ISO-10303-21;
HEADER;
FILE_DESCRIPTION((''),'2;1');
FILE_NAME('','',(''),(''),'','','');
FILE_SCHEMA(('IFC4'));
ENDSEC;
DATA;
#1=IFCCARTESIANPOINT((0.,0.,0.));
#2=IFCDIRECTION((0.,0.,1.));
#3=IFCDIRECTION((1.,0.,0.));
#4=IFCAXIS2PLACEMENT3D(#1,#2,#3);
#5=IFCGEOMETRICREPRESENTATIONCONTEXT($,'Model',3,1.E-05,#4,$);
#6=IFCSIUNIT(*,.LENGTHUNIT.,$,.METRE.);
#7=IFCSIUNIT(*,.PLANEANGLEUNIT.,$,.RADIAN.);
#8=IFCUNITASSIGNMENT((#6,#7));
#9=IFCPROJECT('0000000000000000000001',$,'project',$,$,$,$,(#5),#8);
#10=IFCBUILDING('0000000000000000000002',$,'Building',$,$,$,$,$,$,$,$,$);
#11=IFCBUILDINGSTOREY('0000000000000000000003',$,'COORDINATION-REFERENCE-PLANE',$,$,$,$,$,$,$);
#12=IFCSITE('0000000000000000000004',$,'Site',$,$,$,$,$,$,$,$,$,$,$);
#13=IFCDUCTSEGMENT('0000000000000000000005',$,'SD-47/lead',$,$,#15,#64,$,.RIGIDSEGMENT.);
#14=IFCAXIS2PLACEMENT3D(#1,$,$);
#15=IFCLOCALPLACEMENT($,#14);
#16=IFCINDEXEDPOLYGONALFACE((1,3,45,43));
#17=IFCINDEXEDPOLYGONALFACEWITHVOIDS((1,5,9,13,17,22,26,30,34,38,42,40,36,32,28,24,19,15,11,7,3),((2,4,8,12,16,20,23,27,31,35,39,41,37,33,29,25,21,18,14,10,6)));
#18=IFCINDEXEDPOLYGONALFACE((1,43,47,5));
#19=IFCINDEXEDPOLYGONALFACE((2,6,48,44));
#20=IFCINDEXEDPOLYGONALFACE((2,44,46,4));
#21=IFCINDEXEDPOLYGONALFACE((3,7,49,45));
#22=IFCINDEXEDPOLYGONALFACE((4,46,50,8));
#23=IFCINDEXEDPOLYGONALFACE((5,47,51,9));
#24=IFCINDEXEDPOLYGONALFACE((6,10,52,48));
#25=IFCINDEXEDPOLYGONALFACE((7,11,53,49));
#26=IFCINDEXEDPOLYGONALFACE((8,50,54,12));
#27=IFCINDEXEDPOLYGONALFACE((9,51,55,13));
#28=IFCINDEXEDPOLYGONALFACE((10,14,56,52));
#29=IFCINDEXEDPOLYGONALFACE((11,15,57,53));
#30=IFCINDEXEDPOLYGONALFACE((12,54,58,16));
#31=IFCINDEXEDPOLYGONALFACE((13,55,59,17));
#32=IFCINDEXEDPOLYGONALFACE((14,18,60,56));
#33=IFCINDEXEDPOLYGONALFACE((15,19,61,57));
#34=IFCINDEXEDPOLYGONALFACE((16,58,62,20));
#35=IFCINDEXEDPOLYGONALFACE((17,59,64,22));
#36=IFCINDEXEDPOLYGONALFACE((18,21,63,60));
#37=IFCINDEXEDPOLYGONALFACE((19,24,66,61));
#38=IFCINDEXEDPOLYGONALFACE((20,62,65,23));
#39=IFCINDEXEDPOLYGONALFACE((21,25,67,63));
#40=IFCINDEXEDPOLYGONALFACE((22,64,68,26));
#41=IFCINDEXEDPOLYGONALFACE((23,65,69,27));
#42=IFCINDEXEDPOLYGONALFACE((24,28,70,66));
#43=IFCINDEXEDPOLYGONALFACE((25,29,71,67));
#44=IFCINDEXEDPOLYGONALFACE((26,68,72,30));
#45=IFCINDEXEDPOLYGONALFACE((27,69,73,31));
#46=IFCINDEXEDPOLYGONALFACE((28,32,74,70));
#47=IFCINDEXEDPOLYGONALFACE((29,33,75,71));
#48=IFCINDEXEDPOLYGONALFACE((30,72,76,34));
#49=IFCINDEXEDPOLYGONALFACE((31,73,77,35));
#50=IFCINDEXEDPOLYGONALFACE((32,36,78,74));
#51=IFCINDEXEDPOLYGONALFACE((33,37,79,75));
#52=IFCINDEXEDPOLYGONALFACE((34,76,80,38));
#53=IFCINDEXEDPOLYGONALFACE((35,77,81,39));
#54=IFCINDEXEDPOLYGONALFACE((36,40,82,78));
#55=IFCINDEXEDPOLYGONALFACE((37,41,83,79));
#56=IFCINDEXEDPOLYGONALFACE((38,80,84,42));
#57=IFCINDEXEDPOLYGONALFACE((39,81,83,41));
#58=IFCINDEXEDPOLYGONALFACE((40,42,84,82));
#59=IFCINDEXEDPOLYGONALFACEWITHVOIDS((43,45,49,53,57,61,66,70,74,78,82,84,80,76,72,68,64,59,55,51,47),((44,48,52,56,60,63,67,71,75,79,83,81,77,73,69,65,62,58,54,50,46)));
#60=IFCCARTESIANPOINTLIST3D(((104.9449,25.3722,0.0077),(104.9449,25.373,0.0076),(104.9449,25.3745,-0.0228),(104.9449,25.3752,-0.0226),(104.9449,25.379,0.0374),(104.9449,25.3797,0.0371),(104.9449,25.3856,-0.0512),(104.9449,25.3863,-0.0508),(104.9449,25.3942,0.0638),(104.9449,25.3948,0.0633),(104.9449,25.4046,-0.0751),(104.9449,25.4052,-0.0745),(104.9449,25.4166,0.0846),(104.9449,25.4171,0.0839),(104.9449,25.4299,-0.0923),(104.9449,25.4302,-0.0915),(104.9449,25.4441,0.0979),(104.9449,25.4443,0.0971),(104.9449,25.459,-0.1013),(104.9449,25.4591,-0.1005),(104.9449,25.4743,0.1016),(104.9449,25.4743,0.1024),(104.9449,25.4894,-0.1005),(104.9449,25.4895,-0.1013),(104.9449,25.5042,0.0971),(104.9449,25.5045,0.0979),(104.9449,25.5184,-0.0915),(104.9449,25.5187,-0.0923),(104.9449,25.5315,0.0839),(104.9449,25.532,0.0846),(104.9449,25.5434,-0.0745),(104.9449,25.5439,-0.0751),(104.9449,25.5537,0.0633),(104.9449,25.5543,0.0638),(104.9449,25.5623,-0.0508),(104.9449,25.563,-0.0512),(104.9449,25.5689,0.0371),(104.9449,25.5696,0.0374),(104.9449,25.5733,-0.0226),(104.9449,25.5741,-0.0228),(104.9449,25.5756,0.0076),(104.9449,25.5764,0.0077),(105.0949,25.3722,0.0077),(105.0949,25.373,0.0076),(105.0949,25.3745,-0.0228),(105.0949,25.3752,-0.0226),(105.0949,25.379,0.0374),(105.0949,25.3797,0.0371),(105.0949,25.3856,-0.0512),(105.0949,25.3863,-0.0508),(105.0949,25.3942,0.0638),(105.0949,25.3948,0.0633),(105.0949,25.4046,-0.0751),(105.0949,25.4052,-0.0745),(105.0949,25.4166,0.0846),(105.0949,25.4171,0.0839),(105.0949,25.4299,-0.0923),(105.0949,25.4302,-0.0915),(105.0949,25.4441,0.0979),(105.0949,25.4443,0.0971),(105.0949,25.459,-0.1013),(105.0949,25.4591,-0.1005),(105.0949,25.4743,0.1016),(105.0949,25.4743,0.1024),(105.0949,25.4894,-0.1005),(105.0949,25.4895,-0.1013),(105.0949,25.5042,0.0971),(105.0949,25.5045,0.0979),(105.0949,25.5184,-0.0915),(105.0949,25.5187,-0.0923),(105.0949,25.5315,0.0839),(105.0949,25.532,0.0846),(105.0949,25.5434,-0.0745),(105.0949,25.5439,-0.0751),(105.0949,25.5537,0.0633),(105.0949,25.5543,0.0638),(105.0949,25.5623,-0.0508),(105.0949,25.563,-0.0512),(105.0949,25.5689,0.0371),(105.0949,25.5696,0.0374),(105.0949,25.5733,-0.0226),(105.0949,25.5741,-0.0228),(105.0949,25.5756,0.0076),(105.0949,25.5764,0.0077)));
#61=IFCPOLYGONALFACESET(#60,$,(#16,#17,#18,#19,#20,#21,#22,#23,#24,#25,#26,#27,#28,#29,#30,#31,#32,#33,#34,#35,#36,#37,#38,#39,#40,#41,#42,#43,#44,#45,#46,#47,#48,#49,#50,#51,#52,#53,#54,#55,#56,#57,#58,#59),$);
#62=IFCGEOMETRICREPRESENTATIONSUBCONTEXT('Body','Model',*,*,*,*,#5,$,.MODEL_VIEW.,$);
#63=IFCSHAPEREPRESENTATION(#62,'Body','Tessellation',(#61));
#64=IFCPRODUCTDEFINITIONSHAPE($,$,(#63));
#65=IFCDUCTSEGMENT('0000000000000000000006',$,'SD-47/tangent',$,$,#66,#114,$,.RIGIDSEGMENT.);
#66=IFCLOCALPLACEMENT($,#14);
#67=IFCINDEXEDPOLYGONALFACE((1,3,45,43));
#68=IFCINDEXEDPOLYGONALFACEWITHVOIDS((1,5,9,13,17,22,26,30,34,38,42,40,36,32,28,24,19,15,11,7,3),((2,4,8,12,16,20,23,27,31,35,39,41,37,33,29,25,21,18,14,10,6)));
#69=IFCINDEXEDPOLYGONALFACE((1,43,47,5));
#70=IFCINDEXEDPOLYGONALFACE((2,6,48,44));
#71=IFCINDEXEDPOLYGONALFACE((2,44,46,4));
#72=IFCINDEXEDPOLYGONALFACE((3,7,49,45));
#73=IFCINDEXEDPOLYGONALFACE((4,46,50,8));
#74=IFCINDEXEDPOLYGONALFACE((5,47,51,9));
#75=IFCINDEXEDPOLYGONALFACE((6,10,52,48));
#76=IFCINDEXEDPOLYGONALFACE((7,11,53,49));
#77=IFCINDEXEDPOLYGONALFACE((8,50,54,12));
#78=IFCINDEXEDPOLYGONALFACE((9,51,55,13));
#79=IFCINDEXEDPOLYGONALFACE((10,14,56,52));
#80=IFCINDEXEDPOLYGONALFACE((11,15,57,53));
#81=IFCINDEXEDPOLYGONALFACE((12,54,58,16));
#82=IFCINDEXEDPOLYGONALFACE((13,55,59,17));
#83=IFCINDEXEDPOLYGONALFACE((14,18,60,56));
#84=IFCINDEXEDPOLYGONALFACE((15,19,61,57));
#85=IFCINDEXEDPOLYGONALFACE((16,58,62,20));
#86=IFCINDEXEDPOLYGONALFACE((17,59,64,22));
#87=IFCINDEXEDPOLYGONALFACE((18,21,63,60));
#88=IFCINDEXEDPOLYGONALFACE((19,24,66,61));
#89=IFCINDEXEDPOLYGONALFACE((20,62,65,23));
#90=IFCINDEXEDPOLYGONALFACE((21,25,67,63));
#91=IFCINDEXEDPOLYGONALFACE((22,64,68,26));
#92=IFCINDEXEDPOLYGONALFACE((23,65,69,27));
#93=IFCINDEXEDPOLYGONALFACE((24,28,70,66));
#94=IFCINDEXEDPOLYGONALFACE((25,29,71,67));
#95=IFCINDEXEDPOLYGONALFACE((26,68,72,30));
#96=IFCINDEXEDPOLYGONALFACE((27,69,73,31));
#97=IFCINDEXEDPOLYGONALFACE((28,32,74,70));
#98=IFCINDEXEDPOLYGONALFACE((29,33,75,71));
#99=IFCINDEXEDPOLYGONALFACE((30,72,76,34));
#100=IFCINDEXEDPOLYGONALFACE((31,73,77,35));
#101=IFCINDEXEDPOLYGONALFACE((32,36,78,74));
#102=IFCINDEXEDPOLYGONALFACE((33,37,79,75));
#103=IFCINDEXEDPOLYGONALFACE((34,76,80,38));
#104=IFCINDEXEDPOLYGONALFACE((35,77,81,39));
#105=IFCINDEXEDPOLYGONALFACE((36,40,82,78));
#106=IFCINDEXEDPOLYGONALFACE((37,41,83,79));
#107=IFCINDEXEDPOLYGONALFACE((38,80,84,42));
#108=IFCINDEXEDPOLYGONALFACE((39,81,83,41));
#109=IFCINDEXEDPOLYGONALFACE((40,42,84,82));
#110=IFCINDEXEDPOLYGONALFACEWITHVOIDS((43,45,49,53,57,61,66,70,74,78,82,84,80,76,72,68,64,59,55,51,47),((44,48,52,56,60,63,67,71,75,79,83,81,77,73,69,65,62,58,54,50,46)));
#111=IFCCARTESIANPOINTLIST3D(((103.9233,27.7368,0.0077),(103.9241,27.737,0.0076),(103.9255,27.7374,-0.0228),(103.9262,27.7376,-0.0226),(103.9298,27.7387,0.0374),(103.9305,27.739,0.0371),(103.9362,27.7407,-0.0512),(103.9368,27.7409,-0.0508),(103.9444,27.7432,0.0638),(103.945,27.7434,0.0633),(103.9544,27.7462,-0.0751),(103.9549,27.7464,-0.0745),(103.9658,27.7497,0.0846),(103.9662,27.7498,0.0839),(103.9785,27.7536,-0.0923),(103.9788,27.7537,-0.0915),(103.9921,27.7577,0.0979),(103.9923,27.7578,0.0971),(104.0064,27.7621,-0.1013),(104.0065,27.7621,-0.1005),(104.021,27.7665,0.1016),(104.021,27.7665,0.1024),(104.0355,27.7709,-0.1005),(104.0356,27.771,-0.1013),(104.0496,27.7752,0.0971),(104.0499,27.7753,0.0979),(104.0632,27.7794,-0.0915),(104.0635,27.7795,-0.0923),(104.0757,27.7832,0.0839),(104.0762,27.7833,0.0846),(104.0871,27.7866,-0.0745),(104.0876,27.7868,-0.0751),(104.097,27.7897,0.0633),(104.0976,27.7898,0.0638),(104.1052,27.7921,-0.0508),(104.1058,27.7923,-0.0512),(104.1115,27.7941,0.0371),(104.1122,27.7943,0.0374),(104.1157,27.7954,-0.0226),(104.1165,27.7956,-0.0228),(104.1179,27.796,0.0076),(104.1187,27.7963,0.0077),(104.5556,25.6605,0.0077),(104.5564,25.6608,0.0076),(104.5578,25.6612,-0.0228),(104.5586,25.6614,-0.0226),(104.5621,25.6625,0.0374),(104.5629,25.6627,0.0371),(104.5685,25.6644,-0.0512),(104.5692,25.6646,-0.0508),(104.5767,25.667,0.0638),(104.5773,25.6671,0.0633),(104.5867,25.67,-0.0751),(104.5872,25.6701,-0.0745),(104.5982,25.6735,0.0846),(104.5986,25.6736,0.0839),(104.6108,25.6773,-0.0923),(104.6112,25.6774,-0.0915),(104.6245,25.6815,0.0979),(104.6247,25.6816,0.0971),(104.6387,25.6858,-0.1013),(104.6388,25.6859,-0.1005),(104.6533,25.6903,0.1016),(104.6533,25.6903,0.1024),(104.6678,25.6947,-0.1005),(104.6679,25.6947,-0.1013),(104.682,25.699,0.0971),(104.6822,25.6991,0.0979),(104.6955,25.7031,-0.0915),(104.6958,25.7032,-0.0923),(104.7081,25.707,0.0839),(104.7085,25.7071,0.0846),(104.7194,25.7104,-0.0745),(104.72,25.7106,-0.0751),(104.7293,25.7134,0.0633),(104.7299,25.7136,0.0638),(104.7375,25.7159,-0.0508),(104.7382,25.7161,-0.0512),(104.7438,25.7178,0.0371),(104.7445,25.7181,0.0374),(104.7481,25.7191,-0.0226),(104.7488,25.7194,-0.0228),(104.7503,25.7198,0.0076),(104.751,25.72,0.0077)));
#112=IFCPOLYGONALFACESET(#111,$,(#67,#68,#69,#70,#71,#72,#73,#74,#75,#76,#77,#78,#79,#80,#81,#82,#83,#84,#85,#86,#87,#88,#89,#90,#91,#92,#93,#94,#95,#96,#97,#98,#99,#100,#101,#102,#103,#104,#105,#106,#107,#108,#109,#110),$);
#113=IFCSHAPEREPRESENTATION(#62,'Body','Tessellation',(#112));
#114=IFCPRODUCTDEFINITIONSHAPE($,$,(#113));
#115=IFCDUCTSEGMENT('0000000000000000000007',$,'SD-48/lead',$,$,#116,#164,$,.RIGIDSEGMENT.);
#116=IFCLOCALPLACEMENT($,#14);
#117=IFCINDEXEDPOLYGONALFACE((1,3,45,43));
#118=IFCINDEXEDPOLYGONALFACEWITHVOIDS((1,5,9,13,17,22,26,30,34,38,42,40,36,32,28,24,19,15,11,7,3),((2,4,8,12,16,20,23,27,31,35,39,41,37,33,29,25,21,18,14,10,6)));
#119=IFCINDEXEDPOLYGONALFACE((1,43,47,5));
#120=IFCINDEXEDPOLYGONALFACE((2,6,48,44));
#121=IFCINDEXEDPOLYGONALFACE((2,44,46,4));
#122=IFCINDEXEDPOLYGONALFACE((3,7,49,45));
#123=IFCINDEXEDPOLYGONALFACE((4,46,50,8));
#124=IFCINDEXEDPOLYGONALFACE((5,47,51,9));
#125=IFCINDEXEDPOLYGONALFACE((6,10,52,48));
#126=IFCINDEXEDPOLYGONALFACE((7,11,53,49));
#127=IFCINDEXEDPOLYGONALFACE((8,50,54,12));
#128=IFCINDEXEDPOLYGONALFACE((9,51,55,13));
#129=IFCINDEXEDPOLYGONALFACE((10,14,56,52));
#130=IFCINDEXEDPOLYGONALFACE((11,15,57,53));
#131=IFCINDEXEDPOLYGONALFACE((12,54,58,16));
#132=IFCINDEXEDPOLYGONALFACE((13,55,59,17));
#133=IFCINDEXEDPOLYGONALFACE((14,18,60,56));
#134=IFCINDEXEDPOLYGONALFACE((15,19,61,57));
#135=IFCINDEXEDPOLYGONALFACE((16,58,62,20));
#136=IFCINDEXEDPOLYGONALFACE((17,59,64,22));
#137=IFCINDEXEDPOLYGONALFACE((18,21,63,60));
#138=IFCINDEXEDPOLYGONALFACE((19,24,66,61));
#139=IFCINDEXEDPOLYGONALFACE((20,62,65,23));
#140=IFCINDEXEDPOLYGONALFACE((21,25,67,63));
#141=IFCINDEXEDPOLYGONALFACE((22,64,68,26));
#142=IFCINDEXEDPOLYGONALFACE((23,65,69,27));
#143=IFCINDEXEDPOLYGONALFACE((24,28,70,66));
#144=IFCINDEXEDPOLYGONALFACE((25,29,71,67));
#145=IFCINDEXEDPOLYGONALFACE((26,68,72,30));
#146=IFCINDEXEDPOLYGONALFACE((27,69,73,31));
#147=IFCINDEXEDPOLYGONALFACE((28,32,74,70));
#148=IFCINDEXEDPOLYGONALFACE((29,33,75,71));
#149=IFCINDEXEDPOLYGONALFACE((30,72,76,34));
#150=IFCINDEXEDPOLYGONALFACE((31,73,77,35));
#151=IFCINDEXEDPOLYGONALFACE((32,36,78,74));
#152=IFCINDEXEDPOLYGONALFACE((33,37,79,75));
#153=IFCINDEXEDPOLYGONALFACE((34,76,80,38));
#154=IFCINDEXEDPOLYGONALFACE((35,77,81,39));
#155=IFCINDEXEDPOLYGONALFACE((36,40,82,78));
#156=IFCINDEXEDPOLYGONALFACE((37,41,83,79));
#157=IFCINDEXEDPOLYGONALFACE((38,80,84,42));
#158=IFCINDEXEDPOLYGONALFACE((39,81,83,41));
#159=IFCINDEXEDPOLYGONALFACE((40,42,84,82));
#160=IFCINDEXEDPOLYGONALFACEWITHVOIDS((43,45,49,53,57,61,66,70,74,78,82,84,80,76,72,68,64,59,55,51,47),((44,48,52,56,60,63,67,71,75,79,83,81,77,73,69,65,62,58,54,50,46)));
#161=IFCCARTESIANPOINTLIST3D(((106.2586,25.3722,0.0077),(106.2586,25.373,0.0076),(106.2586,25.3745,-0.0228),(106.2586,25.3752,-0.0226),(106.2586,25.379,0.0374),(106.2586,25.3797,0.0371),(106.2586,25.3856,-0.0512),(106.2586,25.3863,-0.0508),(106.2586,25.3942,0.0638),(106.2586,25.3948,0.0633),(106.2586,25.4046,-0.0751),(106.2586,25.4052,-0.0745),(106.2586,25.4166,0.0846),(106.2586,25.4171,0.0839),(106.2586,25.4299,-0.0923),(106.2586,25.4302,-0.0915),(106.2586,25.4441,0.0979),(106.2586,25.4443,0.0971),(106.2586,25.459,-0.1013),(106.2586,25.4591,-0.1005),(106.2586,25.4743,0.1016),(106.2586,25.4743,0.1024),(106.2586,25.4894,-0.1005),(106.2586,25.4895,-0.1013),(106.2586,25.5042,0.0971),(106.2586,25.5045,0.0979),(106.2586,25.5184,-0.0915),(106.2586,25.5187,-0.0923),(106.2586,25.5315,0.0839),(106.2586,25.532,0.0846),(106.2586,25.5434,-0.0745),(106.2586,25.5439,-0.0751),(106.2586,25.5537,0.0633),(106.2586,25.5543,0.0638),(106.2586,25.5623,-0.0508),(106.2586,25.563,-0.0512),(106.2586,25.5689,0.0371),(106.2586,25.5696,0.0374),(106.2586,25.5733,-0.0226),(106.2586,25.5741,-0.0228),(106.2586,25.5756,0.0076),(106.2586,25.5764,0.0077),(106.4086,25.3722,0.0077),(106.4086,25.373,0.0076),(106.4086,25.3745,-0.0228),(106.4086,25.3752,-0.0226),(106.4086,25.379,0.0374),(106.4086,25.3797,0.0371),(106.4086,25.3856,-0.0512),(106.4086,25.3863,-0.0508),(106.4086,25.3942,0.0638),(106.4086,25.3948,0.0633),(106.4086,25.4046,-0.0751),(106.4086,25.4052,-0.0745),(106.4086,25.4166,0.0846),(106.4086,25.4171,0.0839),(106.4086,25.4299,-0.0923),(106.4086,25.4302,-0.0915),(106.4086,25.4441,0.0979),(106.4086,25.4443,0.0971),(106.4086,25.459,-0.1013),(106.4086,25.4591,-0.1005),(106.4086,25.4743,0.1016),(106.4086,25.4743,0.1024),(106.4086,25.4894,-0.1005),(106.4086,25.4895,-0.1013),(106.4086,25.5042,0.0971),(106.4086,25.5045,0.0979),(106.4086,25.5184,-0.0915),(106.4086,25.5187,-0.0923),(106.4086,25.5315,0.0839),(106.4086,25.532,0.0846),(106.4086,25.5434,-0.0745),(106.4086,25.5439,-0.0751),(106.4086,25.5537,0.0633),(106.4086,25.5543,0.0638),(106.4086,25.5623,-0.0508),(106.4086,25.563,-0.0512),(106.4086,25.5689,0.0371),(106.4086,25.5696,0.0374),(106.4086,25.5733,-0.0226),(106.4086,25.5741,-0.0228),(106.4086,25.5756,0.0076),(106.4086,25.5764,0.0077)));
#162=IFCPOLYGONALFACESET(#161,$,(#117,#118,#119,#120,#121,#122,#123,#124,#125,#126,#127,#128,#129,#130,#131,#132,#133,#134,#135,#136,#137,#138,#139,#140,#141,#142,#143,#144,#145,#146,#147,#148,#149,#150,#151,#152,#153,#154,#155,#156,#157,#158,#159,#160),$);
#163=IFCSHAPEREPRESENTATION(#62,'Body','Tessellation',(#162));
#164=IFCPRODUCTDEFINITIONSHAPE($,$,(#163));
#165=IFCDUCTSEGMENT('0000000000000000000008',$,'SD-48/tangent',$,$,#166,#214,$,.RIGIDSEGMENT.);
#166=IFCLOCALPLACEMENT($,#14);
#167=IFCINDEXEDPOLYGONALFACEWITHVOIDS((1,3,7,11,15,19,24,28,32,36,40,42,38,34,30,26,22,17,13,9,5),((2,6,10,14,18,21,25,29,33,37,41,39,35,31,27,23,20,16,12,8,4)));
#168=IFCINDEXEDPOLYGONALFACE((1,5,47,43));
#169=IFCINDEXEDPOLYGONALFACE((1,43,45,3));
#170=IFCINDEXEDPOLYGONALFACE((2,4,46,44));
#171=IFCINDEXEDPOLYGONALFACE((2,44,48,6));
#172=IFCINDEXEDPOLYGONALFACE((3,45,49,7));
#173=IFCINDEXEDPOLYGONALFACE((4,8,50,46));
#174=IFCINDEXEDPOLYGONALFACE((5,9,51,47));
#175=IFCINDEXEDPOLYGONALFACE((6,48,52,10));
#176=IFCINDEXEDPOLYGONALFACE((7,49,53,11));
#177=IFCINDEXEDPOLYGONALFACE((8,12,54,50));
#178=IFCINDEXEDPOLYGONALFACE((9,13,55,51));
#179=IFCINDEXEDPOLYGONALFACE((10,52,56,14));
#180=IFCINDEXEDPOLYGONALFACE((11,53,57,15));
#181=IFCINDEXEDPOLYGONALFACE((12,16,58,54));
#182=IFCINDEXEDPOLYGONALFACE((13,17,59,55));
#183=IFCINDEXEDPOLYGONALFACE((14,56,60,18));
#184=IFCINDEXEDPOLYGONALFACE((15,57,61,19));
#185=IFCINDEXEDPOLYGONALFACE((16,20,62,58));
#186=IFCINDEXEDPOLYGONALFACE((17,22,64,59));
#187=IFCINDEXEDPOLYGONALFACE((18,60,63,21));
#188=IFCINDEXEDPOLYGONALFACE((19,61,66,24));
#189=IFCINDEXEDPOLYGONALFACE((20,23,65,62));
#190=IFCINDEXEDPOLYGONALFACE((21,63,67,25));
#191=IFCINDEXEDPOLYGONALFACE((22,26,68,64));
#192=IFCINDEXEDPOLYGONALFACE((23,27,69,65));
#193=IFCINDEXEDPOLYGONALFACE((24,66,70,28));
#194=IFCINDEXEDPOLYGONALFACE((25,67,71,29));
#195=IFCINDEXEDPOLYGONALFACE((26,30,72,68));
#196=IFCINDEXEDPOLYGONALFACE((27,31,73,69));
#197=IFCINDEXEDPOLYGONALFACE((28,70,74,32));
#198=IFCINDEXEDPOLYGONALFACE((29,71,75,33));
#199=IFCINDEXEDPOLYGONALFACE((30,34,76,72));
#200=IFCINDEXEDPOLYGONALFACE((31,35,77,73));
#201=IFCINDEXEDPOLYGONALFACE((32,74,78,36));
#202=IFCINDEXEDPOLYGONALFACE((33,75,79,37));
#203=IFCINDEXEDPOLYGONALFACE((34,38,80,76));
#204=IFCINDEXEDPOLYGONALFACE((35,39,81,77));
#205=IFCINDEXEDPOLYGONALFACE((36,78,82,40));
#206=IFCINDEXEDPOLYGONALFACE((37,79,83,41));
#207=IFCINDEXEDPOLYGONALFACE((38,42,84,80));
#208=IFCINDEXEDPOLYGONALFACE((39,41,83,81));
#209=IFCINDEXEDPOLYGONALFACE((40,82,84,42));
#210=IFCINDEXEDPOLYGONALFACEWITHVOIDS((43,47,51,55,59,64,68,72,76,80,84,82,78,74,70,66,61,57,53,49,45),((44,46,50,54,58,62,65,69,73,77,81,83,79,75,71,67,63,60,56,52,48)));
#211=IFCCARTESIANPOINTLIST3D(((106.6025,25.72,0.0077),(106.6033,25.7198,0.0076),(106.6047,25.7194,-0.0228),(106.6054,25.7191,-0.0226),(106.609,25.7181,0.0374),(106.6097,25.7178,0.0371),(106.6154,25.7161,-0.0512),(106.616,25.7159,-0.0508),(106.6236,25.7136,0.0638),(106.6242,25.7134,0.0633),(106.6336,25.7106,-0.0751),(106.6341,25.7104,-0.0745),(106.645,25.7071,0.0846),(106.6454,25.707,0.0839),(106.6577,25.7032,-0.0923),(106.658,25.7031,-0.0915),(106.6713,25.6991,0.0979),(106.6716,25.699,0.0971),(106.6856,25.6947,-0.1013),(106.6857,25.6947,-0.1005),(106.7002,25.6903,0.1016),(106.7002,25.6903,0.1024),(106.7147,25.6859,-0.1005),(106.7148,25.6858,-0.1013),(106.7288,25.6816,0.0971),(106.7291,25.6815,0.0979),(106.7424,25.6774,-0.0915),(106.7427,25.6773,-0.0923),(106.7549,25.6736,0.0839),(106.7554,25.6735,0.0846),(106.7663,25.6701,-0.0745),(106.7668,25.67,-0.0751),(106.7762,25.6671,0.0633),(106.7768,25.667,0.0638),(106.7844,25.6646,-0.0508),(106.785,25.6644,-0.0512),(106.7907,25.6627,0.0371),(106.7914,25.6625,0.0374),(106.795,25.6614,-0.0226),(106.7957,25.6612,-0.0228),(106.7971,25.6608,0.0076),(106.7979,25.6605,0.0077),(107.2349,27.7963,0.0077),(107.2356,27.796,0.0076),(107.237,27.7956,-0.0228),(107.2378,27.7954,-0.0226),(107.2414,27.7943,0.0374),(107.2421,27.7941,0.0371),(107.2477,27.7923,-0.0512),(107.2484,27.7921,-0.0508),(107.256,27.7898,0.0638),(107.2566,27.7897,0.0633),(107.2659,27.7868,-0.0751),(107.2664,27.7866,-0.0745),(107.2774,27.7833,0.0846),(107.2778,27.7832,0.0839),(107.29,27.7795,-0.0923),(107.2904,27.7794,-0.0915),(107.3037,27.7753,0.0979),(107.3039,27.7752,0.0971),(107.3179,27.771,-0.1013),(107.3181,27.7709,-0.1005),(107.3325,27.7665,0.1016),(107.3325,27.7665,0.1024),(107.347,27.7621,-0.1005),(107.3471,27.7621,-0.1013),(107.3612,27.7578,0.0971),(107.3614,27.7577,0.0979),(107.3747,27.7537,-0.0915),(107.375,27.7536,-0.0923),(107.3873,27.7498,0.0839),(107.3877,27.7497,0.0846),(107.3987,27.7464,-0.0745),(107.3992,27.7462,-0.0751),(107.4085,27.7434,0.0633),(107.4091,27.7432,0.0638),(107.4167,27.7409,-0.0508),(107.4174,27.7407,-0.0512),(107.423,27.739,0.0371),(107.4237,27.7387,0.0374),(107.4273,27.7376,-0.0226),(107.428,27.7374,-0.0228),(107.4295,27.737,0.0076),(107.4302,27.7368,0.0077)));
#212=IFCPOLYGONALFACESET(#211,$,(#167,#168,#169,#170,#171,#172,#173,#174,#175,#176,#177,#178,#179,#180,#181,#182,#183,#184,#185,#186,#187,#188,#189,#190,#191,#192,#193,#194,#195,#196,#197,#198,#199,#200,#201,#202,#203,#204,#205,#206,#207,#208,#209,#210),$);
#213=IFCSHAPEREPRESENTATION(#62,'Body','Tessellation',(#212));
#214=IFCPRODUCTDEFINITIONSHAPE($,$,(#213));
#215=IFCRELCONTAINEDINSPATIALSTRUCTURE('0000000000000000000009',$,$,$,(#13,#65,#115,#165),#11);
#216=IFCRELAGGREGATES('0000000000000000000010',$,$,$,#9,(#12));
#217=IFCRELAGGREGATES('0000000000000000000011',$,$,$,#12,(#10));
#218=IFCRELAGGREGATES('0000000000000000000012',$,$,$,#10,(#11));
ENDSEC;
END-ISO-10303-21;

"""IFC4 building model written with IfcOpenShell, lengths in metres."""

from ifc_helpers import new_model, si_unit, frame, origin_with_axes, place, context, subcontext, project, spatial, hollow_circle, extrude, element, save


model = new_model("IFC4")

# Units and contexts
model_context = context("Model", 3, precision=1e-05, world=origin_with_axes())
body_context_1 = subcontext(model_context, "Body", "Model", "MODEL_VIEW")
ifc_project = project(units=[si_unit("LENGTHUNIT", "METRE"), si_unit("PLANEANGLEUNIT", "RADIAN")], contexts=[model_context])

# Site, building, storey
site = spatial("IfcSite", under=ifc_project, Name="Site")
building = spatial("IfcBuilding", under=site, Name="Building")
storey = spatial("IfcBuildingStorey", under=building, Name="COORDINATION-REFERENCE-PLANE")

# Duct segment
duct_segment_1_placement = place(None, frame((105.0949, 25.4743, 0.0), z_axis=(-1.0, 0.0, 0.0), x_axis=(0.0, 0.0, 1.0)))
element("IfcDuctSegment", 1, at=duct_segment_1_placement, inside=storey, Name="SD-47/lead", PredefinedType="RIGIDSEGMENT", context=body_context_1, shape_type="SweptSolid", body=[
    extrude(hollow_circle(Radius=0.1024, WallThickness=0.0008), origin_with_axes(), (0.0, 0.0, 1.0), 0.15),
])

# Duct segment
duct_segment_2_placement = place(None, frame((104.6533, 25.6903, 0.0), z_axis=(-0.291351, 0.956616, 0.0), x_axis=(0.0, 0.0, 1.0)))
element("IfcDuctSegment", 2, at=duct_segment_2_placement, inside=storey, Name="SD-47/tangent", PredefinedType="RIGIDSEGMENT", context=body_context_1, shape_type="SweptSolid", body=[
    extrude(hollow_circle(Radius=0.1024, WallThickness=0.0008), origin_with_axes(), (0.0, 0.0, 1.0), 2.1704),
])

# Duct segment
duct_segment_3_placement = place(None, frame((106.2586, 25.4743, 0.0), z_axis=(1.0, 0.0, 0.0), x_axis=(0.0, 0.0, 1.0)))
element("IfcDuctSegment", 3, at=duct_segment_3_placement, inside=storey, Name="SD-48/lead", PredefinedType="RIGIDSEGMENT", context=body_context_1, shape_type="SweptSolid", body=[
    extrude(hollow_circle(Radius=0.1024, WallThickness=0.0008), origin_with_axes(), (0.0, 0.0, 1.0), 0.15),
])

# Duct segment
duct_segment_4_placement = place(None, frame((106.7002, 25.6903, 0.0), z_axis=(0.291351, 0.956616, 0.0), x_axis=(0.0, 0.0, 1.0)))
element("IfcDuctSegment", 4, at=duct_segment_4_placement, inside=storey, Name="SD-48/tangent", PredefinedType="RIGIDSEGMENT", context=body_context_1, shape_type="SweptSolid", body=[
    extrude(hollow_circle(Radius=0.1024, WallThickness=0.0008), origin_with_axes(), (0.0, 0.0, 1.0), 2.1704),
])

save(model, "model.ifc")
